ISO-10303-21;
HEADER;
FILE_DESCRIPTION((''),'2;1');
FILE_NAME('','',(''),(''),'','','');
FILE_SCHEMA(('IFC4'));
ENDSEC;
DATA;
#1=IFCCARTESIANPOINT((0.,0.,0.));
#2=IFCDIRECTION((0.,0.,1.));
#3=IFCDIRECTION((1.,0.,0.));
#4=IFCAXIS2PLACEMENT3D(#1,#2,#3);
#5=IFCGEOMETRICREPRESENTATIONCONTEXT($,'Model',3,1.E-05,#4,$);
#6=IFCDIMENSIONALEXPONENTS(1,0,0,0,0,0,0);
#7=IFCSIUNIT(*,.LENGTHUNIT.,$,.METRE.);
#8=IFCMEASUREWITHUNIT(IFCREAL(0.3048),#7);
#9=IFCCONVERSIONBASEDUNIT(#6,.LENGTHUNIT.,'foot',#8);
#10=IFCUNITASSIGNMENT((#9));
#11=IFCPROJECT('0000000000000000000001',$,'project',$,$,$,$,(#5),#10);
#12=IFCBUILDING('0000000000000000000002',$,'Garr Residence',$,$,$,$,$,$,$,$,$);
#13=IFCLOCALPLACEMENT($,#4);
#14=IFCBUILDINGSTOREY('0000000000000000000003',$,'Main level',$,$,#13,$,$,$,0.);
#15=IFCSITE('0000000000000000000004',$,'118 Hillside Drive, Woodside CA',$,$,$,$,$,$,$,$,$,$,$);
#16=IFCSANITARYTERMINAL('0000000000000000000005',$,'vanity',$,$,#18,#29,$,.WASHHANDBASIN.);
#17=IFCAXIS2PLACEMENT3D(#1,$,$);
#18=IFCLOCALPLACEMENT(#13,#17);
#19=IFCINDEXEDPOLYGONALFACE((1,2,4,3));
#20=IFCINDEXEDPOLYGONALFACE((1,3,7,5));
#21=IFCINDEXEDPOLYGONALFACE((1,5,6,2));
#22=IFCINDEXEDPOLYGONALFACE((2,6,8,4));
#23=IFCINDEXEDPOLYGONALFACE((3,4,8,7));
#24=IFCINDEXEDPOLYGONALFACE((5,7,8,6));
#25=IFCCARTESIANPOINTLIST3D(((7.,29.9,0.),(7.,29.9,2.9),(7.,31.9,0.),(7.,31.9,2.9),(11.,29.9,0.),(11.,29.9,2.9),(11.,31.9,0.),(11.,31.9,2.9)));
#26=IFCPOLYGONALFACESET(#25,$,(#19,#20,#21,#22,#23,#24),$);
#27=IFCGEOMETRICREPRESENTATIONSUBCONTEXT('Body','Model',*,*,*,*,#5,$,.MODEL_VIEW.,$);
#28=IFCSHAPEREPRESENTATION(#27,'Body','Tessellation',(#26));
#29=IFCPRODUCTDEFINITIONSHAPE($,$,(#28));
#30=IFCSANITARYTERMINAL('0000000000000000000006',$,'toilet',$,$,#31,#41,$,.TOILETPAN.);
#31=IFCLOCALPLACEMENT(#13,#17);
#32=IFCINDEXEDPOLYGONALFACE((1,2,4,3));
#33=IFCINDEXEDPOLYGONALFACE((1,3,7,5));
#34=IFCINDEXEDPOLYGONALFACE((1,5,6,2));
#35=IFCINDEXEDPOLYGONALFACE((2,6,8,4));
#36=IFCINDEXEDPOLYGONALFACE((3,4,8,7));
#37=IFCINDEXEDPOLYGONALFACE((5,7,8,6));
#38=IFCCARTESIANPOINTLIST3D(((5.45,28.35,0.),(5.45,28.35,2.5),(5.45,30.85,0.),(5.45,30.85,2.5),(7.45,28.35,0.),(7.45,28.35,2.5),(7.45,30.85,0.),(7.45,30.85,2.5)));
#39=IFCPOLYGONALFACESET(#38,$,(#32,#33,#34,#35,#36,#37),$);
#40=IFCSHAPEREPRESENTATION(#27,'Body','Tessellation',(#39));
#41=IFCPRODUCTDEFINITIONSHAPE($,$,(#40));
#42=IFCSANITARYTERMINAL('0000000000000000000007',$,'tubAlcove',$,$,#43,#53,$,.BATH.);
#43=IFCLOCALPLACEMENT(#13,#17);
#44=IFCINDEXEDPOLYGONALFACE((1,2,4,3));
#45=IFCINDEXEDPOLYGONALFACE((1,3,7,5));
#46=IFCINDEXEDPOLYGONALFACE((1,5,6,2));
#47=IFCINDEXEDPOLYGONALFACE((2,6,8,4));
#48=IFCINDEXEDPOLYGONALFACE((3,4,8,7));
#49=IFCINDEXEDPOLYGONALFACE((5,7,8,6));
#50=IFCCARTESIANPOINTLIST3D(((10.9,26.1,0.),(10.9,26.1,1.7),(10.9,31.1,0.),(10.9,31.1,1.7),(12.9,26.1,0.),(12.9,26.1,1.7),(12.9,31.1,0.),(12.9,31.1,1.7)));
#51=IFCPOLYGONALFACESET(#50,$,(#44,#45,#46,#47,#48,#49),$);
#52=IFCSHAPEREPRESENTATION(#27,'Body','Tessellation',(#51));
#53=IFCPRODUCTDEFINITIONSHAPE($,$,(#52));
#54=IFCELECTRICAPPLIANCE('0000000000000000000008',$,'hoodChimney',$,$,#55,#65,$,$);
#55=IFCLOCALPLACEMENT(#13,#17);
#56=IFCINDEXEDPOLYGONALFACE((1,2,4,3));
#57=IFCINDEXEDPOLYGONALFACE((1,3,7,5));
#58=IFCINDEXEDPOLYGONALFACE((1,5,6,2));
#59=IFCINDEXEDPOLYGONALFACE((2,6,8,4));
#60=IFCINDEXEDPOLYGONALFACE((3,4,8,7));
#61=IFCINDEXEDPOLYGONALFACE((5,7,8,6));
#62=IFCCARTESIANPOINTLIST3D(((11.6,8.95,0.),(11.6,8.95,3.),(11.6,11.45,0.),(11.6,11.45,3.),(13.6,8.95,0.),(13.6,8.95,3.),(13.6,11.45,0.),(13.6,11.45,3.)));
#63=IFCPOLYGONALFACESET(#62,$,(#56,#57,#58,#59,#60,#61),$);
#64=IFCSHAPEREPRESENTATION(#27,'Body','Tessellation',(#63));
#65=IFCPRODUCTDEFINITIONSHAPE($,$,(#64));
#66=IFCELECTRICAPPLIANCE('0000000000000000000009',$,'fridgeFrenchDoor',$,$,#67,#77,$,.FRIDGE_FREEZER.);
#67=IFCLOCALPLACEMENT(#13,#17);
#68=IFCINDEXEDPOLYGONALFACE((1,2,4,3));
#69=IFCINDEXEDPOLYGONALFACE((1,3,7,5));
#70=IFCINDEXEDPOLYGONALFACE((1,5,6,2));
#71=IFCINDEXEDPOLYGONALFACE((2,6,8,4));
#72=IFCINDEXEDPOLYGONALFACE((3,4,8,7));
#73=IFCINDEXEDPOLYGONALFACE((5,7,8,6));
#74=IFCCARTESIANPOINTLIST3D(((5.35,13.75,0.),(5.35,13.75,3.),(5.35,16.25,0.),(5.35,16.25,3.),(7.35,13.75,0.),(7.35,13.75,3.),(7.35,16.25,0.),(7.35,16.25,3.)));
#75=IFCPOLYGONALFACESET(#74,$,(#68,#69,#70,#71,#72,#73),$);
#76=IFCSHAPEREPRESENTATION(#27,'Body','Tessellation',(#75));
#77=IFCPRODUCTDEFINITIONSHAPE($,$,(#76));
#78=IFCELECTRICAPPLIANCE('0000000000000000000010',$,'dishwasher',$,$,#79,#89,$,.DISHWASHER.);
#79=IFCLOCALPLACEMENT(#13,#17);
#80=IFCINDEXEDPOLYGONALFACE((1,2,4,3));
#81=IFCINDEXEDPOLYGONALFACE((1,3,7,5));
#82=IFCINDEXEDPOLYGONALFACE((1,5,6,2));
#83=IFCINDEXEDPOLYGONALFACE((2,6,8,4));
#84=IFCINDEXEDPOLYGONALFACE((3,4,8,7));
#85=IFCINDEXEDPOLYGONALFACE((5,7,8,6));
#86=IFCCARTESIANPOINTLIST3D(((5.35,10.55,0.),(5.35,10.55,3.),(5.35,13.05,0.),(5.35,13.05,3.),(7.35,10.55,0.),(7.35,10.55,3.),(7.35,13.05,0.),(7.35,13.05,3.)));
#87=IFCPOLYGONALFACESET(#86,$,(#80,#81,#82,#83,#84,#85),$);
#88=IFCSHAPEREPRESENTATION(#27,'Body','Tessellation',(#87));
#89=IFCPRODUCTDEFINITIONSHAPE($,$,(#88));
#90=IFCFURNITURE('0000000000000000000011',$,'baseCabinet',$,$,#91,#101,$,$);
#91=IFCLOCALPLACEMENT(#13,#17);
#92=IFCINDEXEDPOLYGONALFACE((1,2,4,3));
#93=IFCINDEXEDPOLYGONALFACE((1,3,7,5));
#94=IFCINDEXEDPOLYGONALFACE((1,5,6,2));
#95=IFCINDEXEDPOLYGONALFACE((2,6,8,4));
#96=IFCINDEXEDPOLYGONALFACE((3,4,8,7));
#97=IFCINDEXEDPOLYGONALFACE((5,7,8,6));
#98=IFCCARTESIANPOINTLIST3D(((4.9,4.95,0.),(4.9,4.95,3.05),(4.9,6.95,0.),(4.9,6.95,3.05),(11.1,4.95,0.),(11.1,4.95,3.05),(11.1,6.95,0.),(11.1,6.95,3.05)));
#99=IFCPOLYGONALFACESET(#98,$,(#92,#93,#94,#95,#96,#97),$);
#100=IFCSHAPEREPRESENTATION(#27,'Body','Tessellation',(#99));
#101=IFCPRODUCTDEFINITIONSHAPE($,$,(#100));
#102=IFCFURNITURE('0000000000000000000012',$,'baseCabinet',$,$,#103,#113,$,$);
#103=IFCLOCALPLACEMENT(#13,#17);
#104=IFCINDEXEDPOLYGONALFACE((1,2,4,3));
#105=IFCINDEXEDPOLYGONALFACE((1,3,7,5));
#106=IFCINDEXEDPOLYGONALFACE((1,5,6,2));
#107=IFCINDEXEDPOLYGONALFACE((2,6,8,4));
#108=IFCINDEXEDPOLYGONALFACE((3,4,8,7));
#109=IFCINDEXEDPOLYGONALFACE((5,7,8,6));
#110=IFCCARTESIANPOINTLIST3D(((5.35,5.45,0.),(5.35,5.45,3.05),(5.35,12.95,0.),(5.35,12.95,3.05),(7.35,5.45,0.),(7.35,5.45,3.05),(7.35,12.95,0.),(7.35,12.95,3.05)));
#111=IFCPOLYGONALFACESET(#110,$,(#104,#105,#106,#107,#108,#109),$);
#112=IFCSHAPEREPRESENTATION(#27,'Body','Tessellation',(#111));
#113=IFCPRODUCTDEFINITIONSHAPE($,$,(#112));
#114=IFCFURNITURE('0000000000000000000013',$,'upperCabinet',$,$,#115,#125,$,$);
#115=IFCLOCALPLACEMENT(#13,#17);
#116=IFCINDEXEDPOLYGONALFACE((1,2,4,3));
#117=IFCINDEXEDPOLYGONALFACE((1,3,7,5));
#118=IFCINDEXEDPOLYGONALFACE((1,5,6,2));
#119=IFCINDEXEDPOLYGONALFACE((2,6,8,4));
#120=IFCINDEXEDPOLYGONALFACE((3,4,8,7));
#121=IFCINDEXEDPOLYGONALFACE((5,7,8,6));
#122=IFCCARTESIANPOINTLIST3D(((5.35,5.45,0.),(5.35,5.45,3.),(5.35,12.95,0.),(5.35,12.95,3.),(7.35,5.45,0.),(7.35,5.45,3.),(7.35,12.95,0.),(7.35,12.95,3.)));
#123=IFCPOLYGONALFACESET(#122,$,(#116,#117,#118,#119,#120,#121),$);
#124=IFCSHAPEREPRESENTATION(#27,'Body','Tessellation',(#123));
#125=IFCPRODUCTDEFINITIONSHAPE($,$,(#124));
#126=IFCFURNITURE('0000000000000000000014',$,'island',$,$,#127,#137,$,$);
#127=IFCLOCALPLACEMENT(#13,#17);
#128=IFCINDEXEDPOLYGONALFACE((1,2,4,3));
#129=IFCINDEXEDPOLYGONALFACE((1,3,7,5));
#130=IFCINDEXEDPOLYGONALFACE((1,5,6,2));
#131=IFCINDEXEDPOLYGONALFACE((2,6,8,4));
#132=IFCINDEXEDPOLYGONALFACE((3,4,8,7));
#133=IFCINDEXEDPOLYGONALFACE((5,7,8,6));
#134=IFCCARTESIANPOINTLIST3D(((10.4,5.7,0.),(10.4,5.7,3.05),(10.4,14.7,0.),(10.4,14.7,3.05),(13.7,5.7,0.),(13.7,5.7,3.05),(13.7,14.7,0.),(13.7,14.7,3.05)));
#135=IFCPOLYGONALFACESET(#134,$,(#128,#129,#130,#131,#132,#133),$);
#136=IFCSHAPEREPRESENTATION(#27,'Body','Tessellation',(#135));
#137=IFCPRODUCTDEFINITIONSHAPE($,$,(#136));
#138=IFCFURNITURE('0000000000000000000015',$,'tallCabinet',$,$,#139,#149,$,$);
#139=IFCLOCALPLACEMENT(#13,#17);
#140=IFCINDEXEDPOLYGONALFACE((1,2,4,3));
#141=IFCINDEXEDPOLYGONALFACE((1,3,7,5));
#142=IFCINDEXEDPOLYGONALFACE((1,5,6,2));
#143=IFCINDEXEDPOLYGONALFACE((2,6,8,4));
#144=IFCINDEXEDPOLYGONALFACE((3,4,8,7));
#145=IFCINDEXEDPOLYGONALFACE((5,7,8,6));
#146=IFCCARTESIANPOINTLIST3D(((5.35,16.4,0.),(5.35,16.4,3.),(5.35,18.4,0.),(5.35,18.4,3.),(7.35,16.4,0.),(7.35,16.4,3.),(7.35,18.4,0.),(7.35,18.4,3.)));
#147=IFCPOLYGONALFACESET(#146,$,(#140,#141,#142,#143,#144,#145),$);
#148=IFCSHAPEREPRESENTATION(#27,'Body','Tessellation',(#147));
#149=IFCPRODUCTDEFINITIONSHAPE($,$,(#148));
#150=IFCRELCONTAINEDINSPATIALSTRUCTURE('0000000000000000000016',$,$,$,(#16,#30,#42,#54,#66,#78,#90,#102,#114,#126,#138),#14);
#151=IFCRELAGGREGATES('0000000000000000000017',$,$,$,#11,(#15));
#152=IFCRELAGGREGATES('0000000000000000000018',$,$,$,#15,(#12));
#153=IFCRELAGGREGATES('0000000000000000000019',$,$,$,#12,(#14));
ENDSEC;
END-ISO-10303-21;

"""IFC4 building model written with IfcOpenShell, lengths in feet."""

from ifc_helpers import new_model, entity, si_unit, converted_unit, frame, origin, origin_with_axes, place, context, subcontext, project, spatial, polyline, outline, extrude, element, save


model = new_model("IFC4")

# Units and contexts
model_context = context("Model", 3, precision=1e-05, world=origin_with_axes())
body_context = subcontext(model_context, "Body", "Model", "MODEL_VIEW")
ifc_project = project(units=[converted_unit("LENGTHUNIT", "foot", entity("IfcReal", 0.3048), si_unit("LENGTHUNIT", "METRE"), dimensions=[1, 0, 0, 0, 0, 0, 0])], contexts=[model_context])

# Site, building, storey
site = spatial("IfcSite", under=ifc_project, Name="118 Hillside Drive, Woodside CA")
building = spatial("IfcBuilding", under=site, Name="Garr Residence")
storey_placement = place(None, origin_with_axes())
storey = spatial("IfcBuildingStorey", under=building, at=storey_placement, Name="Main level", Elevation=0.0)

# Sanitary terminals
sanitary_terminal_1_placement = place(storey_placement, frame((9.0, 31.9, 0.0), z_axis=(0.0, 0.0, 1.0), x_axis=(-1.0, 0.0, 0.0)))
element("IfcSanitaryTerminal", 1, at=sanitary_terminal_1_placement, inside=storey, Name="vanity", PredefinedType="WASHHANDBASIN", context=body_context, shape_type="SweptSolid", body=[
    extrude(outline(polyline([(-2.0, 0.0), (2.0, 0.0), (2.0, 2.0), (-2.0, 2.0), (-2.0, 0.0)])), origin(), (0.0, 0.0, 1.0), 2.9),
])
sanitary_terminal_2_placement = place(storey_placement, frame((5.45, 29.6, 0.0), z_axis=(0.0, 0.0, 1.0), x_axis=(0.0, -1.0, 0.0)))
element("IfcSanitaryTerminal", 2, at=sanitary_terminal_2_placement, inside=storey, Name="toilet", PredefinedType="TOILETPAN", context=body_context, shape_type="SweptSolid", body=[
    extrude(outline(polyline([(-1.25, 0.0), (1.25, 0.0), (1.25, 2.0), (-1.25, 2.0), (-1.25, 0.0)])), origin(), (0.0, 0.0, 1.0), 2.5),
])
sanitary_terminal_3_placement = place(storey_placement, frame((12.9, 28.6, 0.0), z_axis=(0.0, 0.0, 1.0), x_axis=(0.0, 1.0, 0.0)))
element("IfcSanitaryTerminal", 3, at=sanitary_terminal_3_placement, inside=storey, Name="tubAlcove", PredefinedType="BATH", context=body_context, shape_type="SweptSolid", body=[
    extrude(outline(polyline([(-2.5, 0.0), (2.5, 0.0), (2.5, 2.0), (-2.5, 2.0), (-2.5, 0.0)])), origin(), (0.0, 0.0, 1.0), 1.7),
])

# Electric appliances
electric_appliance_1_placement = place(storey_placement, frame((11.6, 10.2, 0.0), z_axis=(0.0, 0.0, 1.0), x_axis=(0.0, -1.0, 0.0)))
element("IfcElectricAppliance", 4, at=electric_appliance_1_placement, inside=storey, Name="hoodChimney", context=body_context, shape_type="SweptSolid", body=[
    extrude(outline(polyline([(-1.25, 0.0), (1.25, 0.0), (1.25, 2.0), (-1.25, 2.0), (-1.25, 0.0)])), origin(), (0.0, 0.0, 1.0), 3.0),
])
electric_appliance_2_placement = place(storey_placement, frame((5.35, 15.0, 0.0), z_axis=(0.0, 0.0, 1.0), x_axis=(0.0, -1.0, 0.0)))
element("IfcElectricAppliance", 5, at=electric_appliance_2_placement, inside=storey, Name="fridgeFrenchDoor", PredefinedType="FRIDGE_FREEZER", context=body_context, shape_type="SweptSolid", body=[
    extrude(outline(polyline([(-1.25, 0.0), (1.25, 0.0), (1.25, 2.0), (-1.25, 2.0), (-1.25, 0.0)])), origin(), (0.0, 0.0, 1.0), 3.0),
])
electric_appliance_3_placement = place(storey_placement, frame((5.35, 11.8, 0.0), z_axis=(0.0, 0.0, 1.0), x_axis=(0.0, -1.0, 0.0)))
element("IfcElectricAppliance", 6, at=electric_appliance_3_placement, inside=storey, Name="dishwasher", PredefinedType="DISHWASHER", context=body_context, shape_type="SweptSolid", body=[
    extrude(outline(polyline([(-1.25, 0.0), (1.25, 0.0), (1.25, 2.0), (-1.25, 2.0), (-1.25, 0.0)])), origin(), (0.0, 0.0, 1.0), 3.0),
])

# Furniture
furniture_1_placement = place(storey_placement, frame((8.0, 4.95, 0.0), z_axis=(0.0, 0.0, 1.0), x_axis=(1.0, 0.0, 0.0)))
element("IfcFurniture", 7, at=furniture_1_placement, inside=storey, Name="baseCabinet", context=body_context, shape_type="SweptSolid", body=[
    extrude(outline(polyline([(-3.1, 0.0), (3.1, 0.0), (3.1, 2.0), (-3.1, 2.0), (-3.1, 0.0)])), origin(), (0.0, 0.0, 1.0), 3.05),
])
furniture_2_placement = place(storey_placement, frame((5.35, 9.2, 0.0), z_axis=(0.0, 0.0, 1.0), x_axis=(0.0, -1.0, 0.0)))
element("IfcFurniture", 8, at=furniture_2_placement, inside=storey, Name="baseCabinet", context=body_context, shape_type="SweptSolid", body=[
    extrude(outline(polyline([(-3.75, 0.0), (3.75, 0.0), (3.75, 2.0), (-3.75, 2.0), (-3.75, 0.0)])), origin(), (0.0, 0.0, 1.0), 3.05),
])
furniture_3_placement = place(storey_placement, frame((5.35, 9.2, 0.0), z_axis=(0.0, 0.0, 1.0), x_axis=(0.0, -1.0, 0.0)))
element("IfcFurniture", 9, at=furniture_3_placement, inside=storey, Name="upperCabinet", context=body_context, shape_type="SweptSolid", body=[
    extrude(outline(polyline([(-3.75, 0.0), (3.75, 0.0), (3.75, 2.0), (-3.75, 2.0), (-3.75, 0.0)])), origin(), (0.0, 0.0, 1.0), 3.0),
])
furniture_4_placement = place(storey_placement, frame((10.4, 10.2, 0.0), z_axis=(0.0, 0.0, 1.0), x_axis=(0.0, -1.0, 0.0)))
element("IfcFurniture", 10, at=furniture_4_placement, inside=storey, Name="island", context=body_context, shape_type="SweptSolid", body=[
    extrude(outline(polyline([(-4.5, 0.0), (4.5, 0.0), (4.5, 3.3), (-4.5, 3.3), (-4.5, 0.0)])), origin(), (0.0, 0.0, 1.0), 3.05),
])
furniture_5_placement = place(storey_placement, frame((5.35, 17.4, 0.0), z_axis=(0.0, 0.0, 1.0), x_axis=(0.0, -1.0, 0.0)))
element("IfcFurniture", 11, at=furniture_5_placement, inside=storey, Name="tallCabinet", context=body_context, shape_type="SweptSolid", body=[
    extrude(outline(polyline([(-1.0, 0.0), (1.0, 0.0), (1.0, 2.0), (-1.0, 2.0), (-1.0, 0.0)])), origin(), (0.0, 0.0, 1.0), 3.0),
])

save(model, "model.ifc")
